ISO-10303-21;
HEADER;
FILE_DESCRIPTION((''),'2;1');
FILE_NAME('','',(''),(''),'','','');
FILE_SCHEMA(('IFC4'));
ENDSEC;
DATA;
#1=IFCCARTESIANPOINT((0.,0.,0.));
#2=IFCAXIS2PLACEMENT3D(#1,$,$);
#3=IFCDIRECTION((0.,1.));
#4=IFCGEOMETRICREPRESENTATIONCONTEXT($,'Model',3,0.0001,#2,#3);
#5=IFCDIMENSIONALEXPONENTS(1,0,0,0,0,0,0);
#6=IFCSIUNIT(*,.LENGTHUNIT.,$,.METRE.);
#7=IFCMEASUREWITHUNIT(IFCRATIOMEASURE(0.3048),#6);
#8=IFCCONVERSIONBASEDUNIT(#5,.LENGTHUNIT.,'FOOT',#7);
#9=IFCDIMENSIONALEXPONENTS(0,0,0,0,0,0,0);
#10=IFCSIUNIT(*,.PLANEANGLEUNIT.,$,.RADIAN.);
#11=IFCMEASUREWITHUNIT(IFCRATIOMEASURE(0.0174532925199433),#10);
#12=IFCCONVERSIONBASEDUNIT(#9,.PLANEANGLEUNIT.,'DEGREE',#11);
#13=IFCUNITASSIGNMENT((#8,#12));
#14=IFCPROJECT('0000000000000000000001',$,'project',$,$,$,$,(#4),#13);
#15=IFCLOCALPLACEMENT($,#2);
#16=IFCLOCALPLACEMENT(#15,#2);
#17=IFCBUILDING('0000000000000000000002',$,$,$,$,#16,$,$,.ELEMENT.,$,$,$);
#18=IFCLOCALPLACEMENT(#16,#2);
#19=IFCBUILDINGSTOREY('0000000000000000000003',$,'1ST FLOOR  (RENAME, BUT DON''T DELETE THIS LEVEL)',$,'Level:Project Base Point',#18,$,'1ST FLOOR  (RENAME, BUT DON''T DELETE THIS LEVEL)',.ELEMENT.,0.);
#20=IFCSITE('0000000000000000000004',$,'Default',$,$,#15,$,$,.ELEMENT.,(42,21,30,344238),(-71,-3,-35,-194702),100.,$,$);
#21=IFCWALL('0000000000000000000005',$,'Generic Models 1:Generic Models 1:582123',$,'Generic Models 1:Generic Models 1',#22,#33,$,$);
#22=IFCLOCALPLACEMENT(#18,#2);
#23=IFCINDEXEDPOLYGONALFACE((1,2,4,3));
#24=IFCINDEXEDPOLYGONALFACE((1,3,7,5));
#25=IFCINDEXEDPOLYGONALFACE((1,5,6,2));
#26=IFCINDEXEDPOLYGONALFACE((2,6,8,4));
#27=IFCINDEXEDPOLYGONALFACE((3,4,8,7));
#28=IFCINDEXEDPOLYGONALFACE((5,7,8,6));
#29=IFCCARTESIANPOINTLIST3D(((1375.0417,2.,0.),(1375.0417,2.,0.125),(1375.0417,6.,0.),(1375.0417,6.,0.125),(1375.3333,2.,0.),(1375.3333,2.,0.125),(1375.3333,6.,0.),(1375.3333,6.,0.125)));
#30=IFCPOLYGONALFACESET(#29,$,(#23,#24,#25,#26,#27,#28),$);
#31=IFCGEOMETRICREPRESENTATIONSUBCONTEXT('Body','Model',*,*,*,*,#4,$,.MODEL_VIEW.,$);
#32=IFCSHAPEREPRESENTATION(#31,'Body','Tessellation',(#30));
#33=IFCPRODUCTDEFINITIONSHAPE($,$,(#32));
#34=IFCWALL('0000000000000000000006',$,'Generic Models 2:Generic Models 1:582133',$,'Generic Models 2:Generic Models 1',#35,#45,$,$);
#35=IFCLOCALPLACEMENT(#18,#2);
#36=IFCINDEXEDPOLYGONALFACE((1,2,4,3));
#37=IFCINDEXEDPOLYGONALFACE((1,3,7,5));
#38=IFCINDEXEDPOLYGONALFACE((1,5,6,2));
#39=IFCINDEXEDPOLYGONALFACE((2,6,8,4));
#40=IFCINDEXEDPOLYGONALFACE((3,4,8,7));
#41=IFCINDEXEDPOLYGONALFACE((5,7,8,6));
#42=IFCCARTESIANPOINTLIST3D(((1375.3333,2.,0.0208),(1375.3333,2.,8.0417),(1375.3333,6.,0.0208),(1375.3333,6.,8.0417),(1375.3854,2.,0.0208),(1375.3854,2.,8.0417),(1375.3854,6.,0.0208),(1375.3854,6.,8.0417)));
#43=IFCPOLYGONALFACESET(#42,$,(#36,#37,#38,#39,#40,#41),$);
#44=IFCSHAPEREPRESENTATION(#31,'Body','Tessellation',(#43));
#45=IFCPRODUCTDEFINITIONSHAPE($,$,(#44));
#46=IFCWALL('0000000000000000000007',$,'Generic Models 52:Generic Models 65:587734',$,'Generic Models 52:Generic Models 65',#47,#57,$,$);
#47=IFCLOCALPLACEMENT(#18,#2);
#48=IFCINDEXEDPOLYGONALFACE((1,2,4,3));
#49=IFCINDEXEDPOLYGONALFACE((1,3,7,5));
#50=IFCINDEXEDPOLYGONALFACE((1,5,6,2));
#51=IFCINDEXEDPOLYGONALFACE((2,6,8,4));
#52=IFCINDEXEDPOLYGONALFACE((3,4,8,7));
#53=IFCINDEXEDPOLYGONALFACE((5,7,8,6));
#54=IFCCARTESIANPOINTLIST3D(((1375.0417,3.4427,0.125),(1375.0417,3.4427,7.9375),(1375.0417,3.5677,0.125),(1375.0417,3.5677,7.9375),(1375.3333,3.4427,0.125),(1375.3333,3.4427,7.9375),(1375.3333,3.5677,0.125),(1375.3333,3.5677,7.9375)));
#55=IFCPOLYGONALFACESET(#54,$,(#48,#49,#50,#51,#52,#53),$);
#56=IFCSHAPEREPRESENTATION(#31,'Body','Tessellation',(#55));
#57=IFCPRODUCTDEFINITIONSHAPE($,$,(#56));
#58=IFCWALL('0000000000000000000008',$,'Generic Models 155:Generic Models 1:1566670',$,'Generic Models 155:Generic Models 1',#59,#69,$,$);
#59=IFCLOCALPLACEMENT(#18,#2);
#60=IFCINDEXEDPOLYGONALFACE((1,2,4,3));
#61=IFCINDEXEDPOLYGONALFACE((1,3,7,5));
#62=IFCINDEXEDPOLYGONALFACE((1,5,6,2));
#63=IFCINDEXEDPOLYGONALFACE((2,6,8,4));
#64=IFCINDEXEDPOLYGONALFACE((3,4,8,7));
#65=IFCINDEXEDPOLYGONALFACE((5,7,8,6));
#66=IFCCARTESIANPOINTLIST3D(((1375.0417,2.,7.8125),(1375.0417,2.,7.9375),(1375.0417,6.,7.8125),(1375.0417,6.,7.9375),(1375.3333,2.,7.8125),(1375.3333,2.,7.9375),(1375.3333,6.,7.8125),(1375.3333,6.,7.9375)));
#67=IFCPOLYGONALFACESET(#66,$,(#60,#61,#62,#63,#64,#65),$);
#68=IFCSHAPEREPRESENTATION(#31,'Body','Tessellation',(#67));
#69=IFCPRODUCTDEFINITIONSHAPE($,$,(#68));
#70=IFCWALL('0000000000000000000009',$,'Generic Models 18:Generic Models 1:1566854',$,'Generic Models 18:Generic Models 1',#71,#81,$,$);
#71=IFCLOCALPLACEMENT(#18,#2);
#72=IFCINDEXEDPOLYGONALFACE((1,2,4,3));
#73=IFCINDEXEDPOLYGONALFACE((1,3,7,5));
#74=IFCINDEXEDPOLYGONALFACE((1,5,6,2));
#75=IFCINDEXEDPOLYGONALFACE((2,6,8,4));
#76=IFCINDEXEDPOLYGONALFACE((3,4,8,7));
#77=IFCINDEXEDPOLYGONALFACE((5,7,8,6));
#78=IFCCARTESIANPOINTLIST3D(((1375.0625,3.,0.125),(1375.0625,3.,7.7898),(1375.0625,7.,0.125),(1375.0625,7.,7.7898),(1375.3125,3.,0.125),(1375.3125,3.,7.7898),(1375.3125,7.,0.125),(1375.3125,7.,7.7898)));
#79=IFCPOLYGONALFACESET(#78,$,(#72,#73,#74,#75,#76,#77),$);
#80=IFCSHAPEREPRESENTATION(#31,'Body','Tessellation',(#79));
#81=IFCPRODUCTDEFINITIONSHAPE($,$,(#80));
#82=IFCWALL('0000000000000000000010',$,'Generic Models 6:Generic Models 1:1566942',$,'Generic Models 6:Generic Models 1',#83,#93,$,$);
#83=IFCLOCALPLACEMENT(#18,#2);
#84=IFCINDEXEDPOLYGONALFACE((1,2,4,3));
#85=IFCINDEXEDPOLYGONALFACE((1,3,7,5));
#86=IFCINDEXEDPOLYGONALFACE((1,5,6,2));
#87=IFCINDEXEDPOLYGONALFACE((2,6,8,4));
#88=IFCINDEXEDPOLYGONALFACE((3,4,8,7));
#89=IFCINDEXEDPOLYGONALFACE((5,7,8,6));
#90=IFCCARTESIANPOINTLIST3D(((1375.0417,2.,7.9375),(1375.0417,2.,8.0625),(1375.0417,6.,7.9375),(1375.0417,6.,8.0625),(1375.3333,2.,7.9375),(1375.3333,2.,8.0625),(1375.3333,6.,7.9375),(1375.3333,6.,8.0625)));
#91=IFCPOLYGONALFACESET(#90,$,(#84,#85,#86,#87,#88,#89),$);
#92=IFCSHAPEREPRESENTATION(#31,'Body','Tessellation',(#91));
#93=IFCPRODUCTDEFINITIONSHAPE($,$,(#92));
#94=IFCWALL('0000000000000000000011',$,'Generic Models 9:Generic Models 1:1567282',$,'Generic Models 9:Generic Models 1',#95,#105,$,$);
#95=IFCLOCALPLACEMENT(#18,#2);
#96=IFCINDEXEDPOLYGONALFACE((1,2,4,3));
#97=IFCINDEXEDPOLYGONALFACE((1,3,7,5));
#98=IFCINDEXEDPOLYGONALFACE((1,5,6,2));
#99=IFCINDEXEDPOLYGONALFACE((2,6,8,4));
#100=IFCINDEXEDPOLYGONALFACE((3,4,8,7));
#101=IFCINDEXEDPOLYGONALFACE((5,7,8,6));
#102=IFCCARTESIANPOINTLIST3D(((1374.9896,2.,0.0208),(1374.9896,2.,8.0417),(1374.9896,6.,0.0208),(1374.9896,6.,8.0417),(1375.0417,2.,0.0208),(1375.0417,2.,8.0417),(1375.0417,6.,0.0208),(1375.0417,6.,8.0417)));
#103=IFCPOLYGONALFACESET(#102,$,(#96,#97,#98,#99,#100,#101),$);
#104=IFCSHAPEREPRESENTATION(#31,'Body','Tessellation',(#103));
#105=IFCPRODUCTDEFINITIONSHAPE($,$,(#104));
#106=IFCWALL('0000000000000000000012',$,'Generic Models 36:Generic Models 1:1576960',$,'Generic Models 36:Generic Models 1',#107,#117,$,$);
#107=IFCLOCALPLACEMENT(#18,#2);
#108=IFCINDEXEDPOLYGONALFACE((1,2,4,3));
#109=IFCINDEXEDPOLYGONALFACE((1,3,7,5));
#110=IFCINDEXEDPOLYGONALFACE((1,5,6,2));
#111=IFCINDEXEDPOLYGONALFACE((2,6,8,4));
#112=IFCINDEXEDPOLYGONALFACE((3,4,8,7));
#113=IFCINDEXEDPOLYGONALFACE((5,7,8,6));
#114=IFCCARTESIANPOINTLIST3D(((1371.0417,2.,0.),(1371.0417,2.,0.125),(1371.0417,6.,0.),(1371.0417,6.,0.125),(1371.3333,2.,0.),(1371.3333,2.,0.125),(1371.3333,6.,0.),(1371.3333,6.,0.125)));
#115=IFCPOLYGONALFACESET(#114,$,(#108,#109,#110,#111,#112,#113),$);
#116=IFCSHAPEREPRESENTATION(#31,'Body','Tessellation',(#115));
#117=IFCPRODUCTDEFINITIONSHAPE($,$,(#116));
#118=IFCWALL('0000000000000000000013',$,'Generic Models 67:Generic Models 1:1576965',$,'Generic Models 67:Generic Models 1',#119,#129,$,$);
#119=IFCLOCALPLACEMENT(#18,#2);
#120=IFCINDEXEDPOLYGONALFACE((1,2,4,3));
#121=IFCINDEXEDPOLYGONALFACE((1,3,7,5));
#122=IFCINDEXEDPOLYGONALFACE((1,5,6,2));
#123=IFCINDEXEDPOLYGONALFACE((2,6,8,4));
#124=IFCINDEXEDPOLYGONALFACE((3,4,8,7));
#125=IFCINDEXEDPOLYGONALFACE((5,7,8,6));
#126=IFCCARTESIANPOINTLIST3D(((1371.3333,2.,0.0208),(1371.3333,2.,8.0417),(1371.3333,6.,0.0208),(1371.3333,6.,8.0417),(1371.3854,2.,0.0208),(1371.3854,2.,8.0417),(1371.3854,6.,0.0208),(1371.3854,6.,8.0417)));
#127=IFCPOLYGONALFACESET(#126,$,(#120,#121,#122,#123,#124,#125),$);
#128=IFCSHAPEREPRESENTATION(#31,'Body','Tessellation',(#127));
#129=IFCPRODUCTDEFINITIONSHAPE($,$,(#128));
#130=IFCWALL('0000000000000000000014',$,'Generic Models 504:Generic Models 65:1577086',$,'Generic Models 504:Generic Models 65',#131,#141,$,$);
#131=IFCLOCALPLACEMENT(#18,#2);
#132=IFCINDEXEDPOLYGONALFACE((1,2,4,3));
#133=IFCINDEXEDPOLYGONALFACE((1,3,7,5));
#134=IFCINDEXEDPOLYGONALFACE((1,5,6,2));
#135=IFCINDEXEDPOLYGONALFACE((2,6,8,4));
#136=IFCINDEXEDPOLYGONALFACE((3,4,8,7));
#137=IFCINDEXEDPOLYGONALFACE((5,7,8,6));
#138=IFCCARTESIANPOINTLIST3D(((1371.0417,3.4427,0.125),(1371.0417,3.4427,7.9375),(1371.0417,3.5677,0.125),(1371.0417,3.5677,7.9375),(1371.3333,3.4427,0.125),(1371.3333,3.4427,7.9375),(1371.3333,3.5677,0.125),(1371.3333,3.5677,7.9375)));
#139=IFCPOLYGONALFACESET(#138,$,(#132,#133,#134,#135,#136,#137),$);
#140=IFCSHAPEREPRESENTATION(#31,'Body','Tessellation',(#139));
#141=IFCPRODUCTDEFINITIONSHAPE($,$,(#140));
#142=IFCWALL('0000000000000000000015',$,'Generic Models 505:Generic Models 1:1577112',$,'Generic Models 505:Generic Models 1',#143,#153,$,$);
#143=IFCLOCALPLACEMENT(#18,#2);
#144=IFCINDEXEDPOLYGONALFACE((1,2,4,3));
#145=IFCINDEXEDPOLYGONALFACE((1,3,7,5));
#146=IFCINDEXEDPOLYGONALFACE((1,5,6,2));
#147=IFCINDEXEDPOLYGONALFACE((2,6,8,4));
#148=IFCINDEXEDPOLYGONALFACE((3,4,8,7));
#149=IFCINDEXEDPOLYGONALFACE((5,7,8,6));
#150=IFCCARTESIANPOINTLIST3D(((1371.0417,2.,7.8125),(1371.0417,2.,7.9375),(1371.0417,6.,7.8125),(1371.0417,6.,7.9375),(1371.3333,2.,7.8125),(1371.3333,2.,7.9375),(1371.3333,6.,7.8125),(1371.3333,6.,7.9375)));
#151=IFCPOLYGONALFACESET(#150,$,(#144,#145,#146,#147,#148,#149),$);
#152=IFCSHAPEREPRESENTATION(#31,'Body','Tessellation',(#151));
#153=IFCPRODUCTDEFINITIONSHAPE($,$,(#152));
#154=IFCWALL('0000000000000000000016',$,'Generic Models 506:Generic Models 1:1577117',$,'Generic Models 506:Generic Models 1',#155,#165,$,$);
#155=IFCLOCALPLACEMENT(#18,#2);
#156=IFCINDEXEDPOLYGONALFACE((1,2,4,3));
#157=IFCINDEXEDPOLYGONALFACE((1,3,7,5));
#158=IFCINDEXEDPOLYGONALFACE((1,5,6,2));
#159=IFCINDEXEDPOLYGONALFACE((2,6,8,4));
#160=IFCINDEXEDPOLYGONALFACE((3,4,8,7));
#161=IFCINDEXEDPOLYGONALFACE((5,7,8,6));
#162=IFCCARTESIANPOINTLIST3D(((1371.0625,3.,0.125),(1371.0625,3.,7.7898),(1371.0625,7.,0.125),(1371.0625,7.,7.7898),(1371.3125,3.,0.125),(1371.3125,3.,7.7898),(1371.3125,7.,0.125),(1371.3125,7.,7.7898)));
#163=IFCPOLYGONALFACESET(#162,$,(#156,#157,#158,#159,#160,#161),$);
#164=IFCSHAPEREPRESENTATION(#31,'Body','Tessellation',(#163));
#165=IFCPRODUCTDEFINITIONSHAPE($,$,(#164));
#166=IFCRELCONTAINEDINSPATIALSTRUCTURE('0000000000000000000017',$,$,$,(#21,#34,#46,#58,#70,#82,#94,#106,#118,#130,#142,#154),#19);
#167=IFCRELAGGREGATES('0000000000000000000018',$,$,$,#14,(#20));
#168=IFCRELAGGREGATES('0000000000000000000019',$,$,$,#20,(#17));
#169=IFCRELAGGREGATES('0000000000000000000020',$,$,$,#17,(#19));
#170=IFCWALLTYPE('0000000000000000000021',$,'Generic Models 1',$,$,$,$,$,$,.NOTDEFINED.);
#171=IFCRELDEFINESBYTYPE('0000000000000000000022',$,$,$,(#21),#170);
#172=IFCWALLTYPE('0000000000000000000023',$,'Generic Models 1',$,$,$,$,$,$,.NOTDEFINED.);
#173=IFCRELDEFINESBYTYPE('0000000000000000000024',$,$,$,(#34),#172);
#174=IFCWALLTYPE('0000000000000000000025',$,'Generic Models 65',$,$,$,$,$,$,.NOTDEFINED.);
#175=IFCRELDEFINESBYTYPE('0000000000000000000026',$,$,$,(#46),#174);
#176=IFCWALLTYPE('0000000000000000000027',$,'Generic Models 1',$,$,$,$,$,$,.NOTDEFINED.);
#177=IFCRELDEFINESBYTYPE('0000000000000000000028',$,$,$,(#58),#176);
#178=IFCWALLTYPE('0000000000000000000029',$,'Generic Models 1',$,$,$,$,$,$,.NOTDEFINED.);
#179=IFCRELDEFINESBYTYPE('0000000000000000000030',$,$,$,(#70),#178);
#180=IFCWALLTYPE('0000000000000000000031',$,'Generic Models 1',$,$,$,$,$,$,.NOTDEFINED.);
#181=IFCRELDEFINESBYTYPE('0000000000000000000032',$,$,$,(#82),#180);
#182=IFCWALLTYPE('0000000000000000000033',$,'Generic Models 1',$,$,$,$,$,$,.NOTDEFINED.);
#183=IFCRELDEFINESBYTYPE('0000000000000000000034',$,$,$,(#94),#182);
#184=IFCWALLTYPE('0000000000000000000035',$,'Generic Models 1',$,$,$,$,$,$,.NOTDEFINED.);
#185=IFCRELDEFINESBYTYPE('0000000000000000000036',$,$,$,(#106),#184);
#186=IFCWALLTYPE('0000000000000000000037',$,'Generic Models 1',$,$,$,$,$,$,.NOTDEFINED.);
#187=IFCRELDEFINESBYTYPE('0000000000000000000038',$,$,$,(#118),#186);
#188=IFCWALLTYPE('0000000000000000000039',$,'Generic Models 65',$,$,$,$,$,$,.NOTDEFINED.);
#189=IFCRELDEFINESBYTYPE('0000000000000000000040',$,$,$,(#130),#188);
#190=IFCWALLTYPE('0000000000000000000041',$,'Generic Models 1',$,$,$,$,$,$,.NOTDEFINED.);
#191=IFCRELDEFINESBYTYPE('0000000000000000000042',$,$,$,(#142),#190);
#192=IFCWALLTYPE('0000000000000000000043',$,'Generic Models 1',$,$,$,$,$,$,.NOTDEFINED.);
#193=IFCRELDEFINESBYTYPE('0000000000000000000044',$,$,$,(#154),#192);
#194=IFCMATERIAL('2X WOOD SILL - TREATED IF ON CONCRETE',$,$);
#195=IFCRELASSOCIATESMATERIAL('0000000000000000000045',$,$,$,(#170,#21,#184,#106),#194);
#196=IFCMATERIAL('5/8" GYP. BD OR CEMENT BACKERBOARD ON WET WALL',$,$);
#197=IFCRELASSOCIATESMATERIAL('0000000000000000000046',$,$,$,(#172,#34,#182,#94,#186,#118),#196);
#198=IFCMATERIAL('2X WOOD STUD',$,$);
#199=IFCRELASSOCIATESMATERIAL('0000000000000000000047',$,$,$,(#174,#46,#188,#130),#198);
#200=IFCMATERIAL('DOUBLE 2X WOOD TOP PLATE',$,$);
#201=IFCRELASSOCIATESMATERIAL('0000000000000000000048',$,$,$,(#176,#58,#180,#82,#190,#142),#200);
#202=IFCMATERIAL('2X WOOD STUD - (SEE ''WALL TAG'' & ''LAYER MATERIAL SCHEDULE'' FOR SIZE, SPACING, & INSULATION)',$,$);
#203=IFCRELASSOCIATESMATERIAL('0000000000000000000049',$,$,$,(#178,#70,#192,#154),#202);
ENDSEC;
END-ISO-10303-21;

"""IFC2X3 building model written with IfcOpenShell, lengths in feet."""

from ifc_helpers import new_model, entity, si_unit, converted_unit, direction, frame, frame_2d, origin, place, context, subcontext, project, spatial, rectangle, extrude, material, type_object, element, save


model = new_model("IFC2X3")

# Units and contexts
model_context = context("Model", 3, precision=0.0001, world=origin(), true_north=direction((0.0, 1.0)))
body_context = subcontext(model_context, "Body", "Model", "MODEL_VIEW")
ifc_project = project(units=[converted_unit("LENGTHUNIT", "FOOT", entity("IfcRatioMeasure", 0.3048), si_unit("LENGTHUNIT", "METRE"), dimensions=[1, 0, 0, 0, 0, 0, 0]), converted_unit("PLANEANGLEUNIT", "DEGREE", entity("IfcRatioMeasure", 0.0174532925199433), si_unit("PLANEANGLEUNIT", "RADIAN"), dimensions=[0, 0, 0, 0, 0, 0, 0])], contexts=[model_context])

# Site, building, storey
site_placement = place(None, origin())
site = spatial("IfcSite", under=ifc_project, at=site_placement, Name="Default", CompositionType="ELEMENT", RefLatitude=(42, 21, 30, 344238), RefLongitude=(-71, -3, -35, -194702), RefElevation=100.0)
building_placement = place(site_placement, origin())
building = spatial("IfcBuilding", under=site, at=building_placement, CompositionType="ELEMENT")
storey_placement = place(building_placement, origin())
storey = spatial("IfcBuildingStorey", under=building, at=storey_placement, Name="1ST FLOOR  (RENAME, BUT DON'T DELETE THIS LEVEL)", ObjectType="Level:Project Base Point", LongName="1ST FLOOR  (RENAME, BUT DON'T DELETE THIS LEVEL)", CompositionType="ELEMENT", Elevation=0.0)

# Walls
ifc_material_1 = material(Name="2X WOOD SILL - TREATED IF ON CONCRETE")
wall_type_1 = type_object("IfcWallType", Name="Generic Models 1", PredefinedType="NOTDEFINED", material=ifc_material_1)
wall_1_placement = place(storey_placement, frame((1375.0417, 2.0, 0.0), z_axis=(0.0, 0.0, 1.0), x_axis=(0.0, 1.0, 0.0)))
element("IfcWall", 1, at=wall_1_placement, inside=storey, type_object=wall_type_1, material=ifc_material_1, Name="Generic Models 1:Generic Models 1:582123", ObjectType="Generic Models 1:Generic Models 1", context=body_context, shape_type="SweptSolid", body=[
    extrude(rectangle(XDim=4.0, YDim=0.2917, at=frame_2d((0.0, 0.0), x_axis=(1.0, 0.0))), frame((2.0, -0.1458, 0.0)), (0.0, 0.0, 1.0), 0.125),
])
ifc_material_2 = material(Name="5/8\" GYP. BD OR CEMENT BACKERBOARD ON WET WALL")
wall_type_2 = type_object("IfcWallType", Name="Generic Models 1", PredefinedType="NOTDEFINED", material=ifc_material_2)
wall_2_placement = place(storey_placement, frame((1375.3333, 2.0, 0.0208), z_axis=(0.0, 0.0, 1.0), x_axis=(0.0, 1.0, 0.0)))
element("IfcWall", 2, at=wall_2_placement, inside=storey, type_object=wall_type_2, material=ifc_material_2, Name="Generic Models 2:Generic Models 1:582133", ObjectType="Generic Models 2:Generic Models 1", context=body_context, shape_type="SweptSolid", body=[
    extrude(rectangle(XDim=4.0, YDim=0.0521, at=frame_2d((0.0, 0.0), x_axis=(1.0, 0.0))), frame((2.0, -0.026, 0.0)), (0.0, 0.0, 1.0), 8.0208),
])
ifc_material_3 = material(Name="2X WOOD STUD")
wall_type_3 = type_object("IfcWallType", Name="Generic Models 65", PredefinedType="NOTDEFINED", material=ifc_material_3)
wall_3_placement = place(storey_placement, frame((1375.0417, 3.4427, 0.125)))
element("IfcWall", 3, at=wall_3_placement, inside=storey, type_object=wall_type_3, material=ifc_material_3, Name="Generic Models 52:Generic Models 65:587734", ObjectType="Generic Models 52:Generic Models 65", context=body_context, shape_type="SweptSolid", body=[
    extrude(rectangle(XDim=0.125, YDim=0.2917, at=frame_2d((0.0, 0.0), x_axis=(1.0, 0.0))), frame((0.1458, 0.0625, 0.0), z_axis=(0.0, 0.0, 1.0), x_axis=(0.0, 1.0, 0.0)), (0.0, 0.0, 1.0), 7.8125),
])
ifc_material_4 = material(Name="DOUBLE 2X WOOD TOP PLATE")
wall_type_4 = type_object("IfcWallType", Name="Generic Models 1", PredefinedType="NOTDEFINED", material=ifc_material_4)
wall_4_placement = place(storey_placement, frame((1375.0417, 2.0, 7.8125), z_axis=(0.0, 0.0, 1.0), x_axis=(0.0, 1.0, 0.0)))
element("IfcWall", 4, at=wall_4_placement, inside=storey, type_object=wall_type_4, material=ifc_material_4, Name="Generic Models 155:Generic Models 1:1566670", ObjectType="Generic Models 155:Generic Models 1", context=body_context, shape_type="SweptSolid", body=[
    extrude(rectangle(XDim=4.0, YDim=0.2917, at=frame_2d((0.0, 0.0), x_axis=(1.0, 0.0))), frame((2.0, -0.1458, 0.0)), (0.0, 0.0, 1.0), 0.125),
])
ifc_material_5 = material(Name="2X WOOD STUD - (SEE 'WALL TAG' & 'LAYER MATERIAL SCHEDULE' FOR SIZE, SPACING, & INSULATION)")
wall_type_5 = type_object("IfcWallType", Name="Generic Models 1", PredefinedType="NOTDEFINED", material=ifc_material_5)
wall_5_placement = place(storey_placement, frame((1375.0625, 3.0, 0.125), z_axis=(0.0, 0.0, 1.0), x_axis=(0.0, 1.0, 0.0)))
element("IfcWall", 5, at=wall_5_placement, inside=storey, type_object=wall_type_5, material=ifc_material_5, Name="Generic Models 18:Generic Models 1:1566854", ObjectType="Generic Models 18:Generic Models 1", context=body_context, shape_type="SweptSolid", body=[
    extrude(rectangle(XDim=4.0, YDim=0.25, at=frame_2d((0.0, 0.0), x_axis=(1.0, 0.0))), frame((2.0, -0.125, 0.0)), (0.0, 0.0, 1.0), 7.6648),
])
wall_type_6 = type_object("IfcWallType", Name="Generic Models 1", PredefinedType="NOTDEFINED", material=ifc_material_4)
wall_6_placement = place(storey_placement, frame((1375.0417, 2.0, 7.9375), z_axis=(0.0, 0.0, 1.0), x_axis=(0.0, 1.0, 0.0)))
element("IfcWall", 6, at=wall_6_placement, inside=storey, type_object=wall_type_6, material=ifc_material_4, Name="Generic Models 6:Generic Models 1:1566942", ObjectType="Generic Models 6:Generic Models 1", context=body_context, shape_type="SweptSolid", body=[
    extrude(rectangle(XDim=4.0, YDim=0.2917, at=frame_2d((0.0, 0.0), x_axis=(1.0, 0.0))), frame((2.0, -0.1458, 0.0)), (0.0, 0.0, 1.0), 0.125),
])
wall_type_7 = type_object("IfcWallType", Name="Generic Models 1", PredefinedType="NOTDEFINED", material=ifc_material_2)
wall_7_placement = place(storey_placement, frame((1374.9896, 2.0, 0.0208), z_axis=(0.0, 0.0, 1.0), x_axis=(0.0, 1.0, 0.0)))
element("IfcWall", 7, at=wall_7_placement, inside=storey, type_object=wall_type_7, material=ifc_material_2, Name="Generic Models 9:Generic Models 1:1567282", ObjectType="Generic Models 9:Generic Models 1", context=body_context, shape_type="SweptSolid", body=[
    extrude(rectangle(XDim=4.0, YDim=0.0521, at=frame_2d((0.0, 0.0), x_axis=(1.0, 0.0))), frame((2.0, -0.026, 0.0)), (0.0, 0.0, 1.0), 8.0208),
])
wall_type_8 = type_object("IfcWallType", Name="Generic Models 1", PredefinedType="NOTDEFINED", material=ifc_material_1)
wall_8_placement = place(storey_placement, frame((1371.0417, 2.0, 0.0), z_axis=(0.0, 0.0, 1.0), x_axis=(0.0, 1.0, 0.0)))
element("IfcWall", 8, at=wall_8_placement, inside=storey, type_object=wall_type_8, material=ifc_material_1, Name="Generic Models 36:Generic Models 1:1576960", ObjectType="Generic Models 36:Generic Models 1", context=body_context, shape_type="SweptSolid", body=[
    extrude(rectangle(XDim=4.0, YDim=0.2917, at=frame_2d((0.0, 0.0), x_axis=(1.0, 0.0))), frame((2.0, -0.1458, 0.0)), (0.0, 0.0, 1.0), 0.125),
])
wall_type_9 = type_object("IfcWallType", Name="Generic Models 1", PredefinedType="NOTDEFINED", material=ifc_material_2)
wall_9_placement = place(storey_placement, frame((1371.3333, 2.0, 0.0208), z_axis=(0.0, 0.0, 1.0), x_axis=(0.0, 1.0, 0.0)))
element("IfcWall", 9, at=wall_9_placement, inside=storey, type_object=wall_type_9, material=ifc_material_2, Name="Generic Models 67:Generic Models 1:1576965", ObjectType="Generic Models 67:Generic Models 1", context=body_context, shape_type="SweptSolid", body=[
    extrude(rectangle(XDim=4.0, YDim=0.0521, at=frame_2d((0.0, 0.0), x_axis=(1.0, 0.0))), frame((2.0, -0.026, 0.0)), (0.0, 0.0, 1.0), 8.0208),
])
wall_type_10 = type_object("IfcWallType", Name="Generic Models 65", PredefinedType="NOTDEFINED", material=ifc_material_3)
wall_10_placement = place(storey_placement, frame((1371.0417, 3.4427, 0.125)))
element("IfcWall", 10, at=wall_10_placement, inside=storey, type_object=wall_type_10, material=ifc_material_3, Name="Generic Models 504:Generic Models 65:1577086", ObjectType="Generic Models 504:Generic Models 65", context=body_context, shape_type="SweptSolid", body=[
    extrude(rectangle(XDim=0.125, YDim=0.2917, at=frame_2d((0.0, 0.0), x_axis=(1.0, 0.0))), frame((0.1458, 0.0625, 0.0), z_axis=(0.0, 0.0, 1.0), x_axis=(0.0, 1.0, 0.0)), (0.0, 0.0, 1.0), 7.8125),
])
wall_type_11 = type_object("IfcWallType", Name="Generic Models 1", PredefinedType="NOTDEFINED", material=ifc_material_4)
wall_11_placement = place(storey_placement, frame((1371.0417, 2.0, 7.8125), z_axis=(0.0, 0.0, 1.0), x_axis=(0.0, 1.0, 0.0)))
element("IfcWall", 11, at=wall_11_placement, inside=storey, type_object=wall_type_11, material=ifc_material_4, Name="Generic Models 505:Generic Models 1:1577112", ObjectType="Generic Models 505:Generic Models 1", context=body_context, shape_type="SweptSolid", body=[
    extrude(rectangle(XDim=4.0, YDim=0.2917, at=frame_2d((0.0, 0.0), x_axis=(1.0, 0.0))), frame((2.0, -0.1458, 0.0)), (0.0, 0.0, 1.0), 0.125),
])
wall_type_12 = type_object("IfcWallType", Name="Generic Models 1", PredefinedType="NOTDEFINED", material=ifc_material_5)
wall_12_placement = place(storey_placement, frame((1371.0625, 3.0, 0.125), z_axis=(0.0, 0.0, 1.0), x_axis=(0.0, 1.0, 0.0)))
element("IfcWall", 12, at=wall_12_placement, inside=storey, type_object=wall_type_12, material=ifc_material_5, Name="Generic Models 506:Generic Models 1:1577117", ObjectType="Generic Models 506:Generic Models 1", context=body_context, shape_type="SweptSolid", body=[
    extrude(rectangle(XDim=4.0, YDim=0.25, at=frame_2d((0.0, 0.0), x_axis=(1.0, 0.0))), frame((2.0, -0.125, 0.0)), (0.0, 0.0, 1.0), 7.6648),
])

save(model, "model.ifc")
